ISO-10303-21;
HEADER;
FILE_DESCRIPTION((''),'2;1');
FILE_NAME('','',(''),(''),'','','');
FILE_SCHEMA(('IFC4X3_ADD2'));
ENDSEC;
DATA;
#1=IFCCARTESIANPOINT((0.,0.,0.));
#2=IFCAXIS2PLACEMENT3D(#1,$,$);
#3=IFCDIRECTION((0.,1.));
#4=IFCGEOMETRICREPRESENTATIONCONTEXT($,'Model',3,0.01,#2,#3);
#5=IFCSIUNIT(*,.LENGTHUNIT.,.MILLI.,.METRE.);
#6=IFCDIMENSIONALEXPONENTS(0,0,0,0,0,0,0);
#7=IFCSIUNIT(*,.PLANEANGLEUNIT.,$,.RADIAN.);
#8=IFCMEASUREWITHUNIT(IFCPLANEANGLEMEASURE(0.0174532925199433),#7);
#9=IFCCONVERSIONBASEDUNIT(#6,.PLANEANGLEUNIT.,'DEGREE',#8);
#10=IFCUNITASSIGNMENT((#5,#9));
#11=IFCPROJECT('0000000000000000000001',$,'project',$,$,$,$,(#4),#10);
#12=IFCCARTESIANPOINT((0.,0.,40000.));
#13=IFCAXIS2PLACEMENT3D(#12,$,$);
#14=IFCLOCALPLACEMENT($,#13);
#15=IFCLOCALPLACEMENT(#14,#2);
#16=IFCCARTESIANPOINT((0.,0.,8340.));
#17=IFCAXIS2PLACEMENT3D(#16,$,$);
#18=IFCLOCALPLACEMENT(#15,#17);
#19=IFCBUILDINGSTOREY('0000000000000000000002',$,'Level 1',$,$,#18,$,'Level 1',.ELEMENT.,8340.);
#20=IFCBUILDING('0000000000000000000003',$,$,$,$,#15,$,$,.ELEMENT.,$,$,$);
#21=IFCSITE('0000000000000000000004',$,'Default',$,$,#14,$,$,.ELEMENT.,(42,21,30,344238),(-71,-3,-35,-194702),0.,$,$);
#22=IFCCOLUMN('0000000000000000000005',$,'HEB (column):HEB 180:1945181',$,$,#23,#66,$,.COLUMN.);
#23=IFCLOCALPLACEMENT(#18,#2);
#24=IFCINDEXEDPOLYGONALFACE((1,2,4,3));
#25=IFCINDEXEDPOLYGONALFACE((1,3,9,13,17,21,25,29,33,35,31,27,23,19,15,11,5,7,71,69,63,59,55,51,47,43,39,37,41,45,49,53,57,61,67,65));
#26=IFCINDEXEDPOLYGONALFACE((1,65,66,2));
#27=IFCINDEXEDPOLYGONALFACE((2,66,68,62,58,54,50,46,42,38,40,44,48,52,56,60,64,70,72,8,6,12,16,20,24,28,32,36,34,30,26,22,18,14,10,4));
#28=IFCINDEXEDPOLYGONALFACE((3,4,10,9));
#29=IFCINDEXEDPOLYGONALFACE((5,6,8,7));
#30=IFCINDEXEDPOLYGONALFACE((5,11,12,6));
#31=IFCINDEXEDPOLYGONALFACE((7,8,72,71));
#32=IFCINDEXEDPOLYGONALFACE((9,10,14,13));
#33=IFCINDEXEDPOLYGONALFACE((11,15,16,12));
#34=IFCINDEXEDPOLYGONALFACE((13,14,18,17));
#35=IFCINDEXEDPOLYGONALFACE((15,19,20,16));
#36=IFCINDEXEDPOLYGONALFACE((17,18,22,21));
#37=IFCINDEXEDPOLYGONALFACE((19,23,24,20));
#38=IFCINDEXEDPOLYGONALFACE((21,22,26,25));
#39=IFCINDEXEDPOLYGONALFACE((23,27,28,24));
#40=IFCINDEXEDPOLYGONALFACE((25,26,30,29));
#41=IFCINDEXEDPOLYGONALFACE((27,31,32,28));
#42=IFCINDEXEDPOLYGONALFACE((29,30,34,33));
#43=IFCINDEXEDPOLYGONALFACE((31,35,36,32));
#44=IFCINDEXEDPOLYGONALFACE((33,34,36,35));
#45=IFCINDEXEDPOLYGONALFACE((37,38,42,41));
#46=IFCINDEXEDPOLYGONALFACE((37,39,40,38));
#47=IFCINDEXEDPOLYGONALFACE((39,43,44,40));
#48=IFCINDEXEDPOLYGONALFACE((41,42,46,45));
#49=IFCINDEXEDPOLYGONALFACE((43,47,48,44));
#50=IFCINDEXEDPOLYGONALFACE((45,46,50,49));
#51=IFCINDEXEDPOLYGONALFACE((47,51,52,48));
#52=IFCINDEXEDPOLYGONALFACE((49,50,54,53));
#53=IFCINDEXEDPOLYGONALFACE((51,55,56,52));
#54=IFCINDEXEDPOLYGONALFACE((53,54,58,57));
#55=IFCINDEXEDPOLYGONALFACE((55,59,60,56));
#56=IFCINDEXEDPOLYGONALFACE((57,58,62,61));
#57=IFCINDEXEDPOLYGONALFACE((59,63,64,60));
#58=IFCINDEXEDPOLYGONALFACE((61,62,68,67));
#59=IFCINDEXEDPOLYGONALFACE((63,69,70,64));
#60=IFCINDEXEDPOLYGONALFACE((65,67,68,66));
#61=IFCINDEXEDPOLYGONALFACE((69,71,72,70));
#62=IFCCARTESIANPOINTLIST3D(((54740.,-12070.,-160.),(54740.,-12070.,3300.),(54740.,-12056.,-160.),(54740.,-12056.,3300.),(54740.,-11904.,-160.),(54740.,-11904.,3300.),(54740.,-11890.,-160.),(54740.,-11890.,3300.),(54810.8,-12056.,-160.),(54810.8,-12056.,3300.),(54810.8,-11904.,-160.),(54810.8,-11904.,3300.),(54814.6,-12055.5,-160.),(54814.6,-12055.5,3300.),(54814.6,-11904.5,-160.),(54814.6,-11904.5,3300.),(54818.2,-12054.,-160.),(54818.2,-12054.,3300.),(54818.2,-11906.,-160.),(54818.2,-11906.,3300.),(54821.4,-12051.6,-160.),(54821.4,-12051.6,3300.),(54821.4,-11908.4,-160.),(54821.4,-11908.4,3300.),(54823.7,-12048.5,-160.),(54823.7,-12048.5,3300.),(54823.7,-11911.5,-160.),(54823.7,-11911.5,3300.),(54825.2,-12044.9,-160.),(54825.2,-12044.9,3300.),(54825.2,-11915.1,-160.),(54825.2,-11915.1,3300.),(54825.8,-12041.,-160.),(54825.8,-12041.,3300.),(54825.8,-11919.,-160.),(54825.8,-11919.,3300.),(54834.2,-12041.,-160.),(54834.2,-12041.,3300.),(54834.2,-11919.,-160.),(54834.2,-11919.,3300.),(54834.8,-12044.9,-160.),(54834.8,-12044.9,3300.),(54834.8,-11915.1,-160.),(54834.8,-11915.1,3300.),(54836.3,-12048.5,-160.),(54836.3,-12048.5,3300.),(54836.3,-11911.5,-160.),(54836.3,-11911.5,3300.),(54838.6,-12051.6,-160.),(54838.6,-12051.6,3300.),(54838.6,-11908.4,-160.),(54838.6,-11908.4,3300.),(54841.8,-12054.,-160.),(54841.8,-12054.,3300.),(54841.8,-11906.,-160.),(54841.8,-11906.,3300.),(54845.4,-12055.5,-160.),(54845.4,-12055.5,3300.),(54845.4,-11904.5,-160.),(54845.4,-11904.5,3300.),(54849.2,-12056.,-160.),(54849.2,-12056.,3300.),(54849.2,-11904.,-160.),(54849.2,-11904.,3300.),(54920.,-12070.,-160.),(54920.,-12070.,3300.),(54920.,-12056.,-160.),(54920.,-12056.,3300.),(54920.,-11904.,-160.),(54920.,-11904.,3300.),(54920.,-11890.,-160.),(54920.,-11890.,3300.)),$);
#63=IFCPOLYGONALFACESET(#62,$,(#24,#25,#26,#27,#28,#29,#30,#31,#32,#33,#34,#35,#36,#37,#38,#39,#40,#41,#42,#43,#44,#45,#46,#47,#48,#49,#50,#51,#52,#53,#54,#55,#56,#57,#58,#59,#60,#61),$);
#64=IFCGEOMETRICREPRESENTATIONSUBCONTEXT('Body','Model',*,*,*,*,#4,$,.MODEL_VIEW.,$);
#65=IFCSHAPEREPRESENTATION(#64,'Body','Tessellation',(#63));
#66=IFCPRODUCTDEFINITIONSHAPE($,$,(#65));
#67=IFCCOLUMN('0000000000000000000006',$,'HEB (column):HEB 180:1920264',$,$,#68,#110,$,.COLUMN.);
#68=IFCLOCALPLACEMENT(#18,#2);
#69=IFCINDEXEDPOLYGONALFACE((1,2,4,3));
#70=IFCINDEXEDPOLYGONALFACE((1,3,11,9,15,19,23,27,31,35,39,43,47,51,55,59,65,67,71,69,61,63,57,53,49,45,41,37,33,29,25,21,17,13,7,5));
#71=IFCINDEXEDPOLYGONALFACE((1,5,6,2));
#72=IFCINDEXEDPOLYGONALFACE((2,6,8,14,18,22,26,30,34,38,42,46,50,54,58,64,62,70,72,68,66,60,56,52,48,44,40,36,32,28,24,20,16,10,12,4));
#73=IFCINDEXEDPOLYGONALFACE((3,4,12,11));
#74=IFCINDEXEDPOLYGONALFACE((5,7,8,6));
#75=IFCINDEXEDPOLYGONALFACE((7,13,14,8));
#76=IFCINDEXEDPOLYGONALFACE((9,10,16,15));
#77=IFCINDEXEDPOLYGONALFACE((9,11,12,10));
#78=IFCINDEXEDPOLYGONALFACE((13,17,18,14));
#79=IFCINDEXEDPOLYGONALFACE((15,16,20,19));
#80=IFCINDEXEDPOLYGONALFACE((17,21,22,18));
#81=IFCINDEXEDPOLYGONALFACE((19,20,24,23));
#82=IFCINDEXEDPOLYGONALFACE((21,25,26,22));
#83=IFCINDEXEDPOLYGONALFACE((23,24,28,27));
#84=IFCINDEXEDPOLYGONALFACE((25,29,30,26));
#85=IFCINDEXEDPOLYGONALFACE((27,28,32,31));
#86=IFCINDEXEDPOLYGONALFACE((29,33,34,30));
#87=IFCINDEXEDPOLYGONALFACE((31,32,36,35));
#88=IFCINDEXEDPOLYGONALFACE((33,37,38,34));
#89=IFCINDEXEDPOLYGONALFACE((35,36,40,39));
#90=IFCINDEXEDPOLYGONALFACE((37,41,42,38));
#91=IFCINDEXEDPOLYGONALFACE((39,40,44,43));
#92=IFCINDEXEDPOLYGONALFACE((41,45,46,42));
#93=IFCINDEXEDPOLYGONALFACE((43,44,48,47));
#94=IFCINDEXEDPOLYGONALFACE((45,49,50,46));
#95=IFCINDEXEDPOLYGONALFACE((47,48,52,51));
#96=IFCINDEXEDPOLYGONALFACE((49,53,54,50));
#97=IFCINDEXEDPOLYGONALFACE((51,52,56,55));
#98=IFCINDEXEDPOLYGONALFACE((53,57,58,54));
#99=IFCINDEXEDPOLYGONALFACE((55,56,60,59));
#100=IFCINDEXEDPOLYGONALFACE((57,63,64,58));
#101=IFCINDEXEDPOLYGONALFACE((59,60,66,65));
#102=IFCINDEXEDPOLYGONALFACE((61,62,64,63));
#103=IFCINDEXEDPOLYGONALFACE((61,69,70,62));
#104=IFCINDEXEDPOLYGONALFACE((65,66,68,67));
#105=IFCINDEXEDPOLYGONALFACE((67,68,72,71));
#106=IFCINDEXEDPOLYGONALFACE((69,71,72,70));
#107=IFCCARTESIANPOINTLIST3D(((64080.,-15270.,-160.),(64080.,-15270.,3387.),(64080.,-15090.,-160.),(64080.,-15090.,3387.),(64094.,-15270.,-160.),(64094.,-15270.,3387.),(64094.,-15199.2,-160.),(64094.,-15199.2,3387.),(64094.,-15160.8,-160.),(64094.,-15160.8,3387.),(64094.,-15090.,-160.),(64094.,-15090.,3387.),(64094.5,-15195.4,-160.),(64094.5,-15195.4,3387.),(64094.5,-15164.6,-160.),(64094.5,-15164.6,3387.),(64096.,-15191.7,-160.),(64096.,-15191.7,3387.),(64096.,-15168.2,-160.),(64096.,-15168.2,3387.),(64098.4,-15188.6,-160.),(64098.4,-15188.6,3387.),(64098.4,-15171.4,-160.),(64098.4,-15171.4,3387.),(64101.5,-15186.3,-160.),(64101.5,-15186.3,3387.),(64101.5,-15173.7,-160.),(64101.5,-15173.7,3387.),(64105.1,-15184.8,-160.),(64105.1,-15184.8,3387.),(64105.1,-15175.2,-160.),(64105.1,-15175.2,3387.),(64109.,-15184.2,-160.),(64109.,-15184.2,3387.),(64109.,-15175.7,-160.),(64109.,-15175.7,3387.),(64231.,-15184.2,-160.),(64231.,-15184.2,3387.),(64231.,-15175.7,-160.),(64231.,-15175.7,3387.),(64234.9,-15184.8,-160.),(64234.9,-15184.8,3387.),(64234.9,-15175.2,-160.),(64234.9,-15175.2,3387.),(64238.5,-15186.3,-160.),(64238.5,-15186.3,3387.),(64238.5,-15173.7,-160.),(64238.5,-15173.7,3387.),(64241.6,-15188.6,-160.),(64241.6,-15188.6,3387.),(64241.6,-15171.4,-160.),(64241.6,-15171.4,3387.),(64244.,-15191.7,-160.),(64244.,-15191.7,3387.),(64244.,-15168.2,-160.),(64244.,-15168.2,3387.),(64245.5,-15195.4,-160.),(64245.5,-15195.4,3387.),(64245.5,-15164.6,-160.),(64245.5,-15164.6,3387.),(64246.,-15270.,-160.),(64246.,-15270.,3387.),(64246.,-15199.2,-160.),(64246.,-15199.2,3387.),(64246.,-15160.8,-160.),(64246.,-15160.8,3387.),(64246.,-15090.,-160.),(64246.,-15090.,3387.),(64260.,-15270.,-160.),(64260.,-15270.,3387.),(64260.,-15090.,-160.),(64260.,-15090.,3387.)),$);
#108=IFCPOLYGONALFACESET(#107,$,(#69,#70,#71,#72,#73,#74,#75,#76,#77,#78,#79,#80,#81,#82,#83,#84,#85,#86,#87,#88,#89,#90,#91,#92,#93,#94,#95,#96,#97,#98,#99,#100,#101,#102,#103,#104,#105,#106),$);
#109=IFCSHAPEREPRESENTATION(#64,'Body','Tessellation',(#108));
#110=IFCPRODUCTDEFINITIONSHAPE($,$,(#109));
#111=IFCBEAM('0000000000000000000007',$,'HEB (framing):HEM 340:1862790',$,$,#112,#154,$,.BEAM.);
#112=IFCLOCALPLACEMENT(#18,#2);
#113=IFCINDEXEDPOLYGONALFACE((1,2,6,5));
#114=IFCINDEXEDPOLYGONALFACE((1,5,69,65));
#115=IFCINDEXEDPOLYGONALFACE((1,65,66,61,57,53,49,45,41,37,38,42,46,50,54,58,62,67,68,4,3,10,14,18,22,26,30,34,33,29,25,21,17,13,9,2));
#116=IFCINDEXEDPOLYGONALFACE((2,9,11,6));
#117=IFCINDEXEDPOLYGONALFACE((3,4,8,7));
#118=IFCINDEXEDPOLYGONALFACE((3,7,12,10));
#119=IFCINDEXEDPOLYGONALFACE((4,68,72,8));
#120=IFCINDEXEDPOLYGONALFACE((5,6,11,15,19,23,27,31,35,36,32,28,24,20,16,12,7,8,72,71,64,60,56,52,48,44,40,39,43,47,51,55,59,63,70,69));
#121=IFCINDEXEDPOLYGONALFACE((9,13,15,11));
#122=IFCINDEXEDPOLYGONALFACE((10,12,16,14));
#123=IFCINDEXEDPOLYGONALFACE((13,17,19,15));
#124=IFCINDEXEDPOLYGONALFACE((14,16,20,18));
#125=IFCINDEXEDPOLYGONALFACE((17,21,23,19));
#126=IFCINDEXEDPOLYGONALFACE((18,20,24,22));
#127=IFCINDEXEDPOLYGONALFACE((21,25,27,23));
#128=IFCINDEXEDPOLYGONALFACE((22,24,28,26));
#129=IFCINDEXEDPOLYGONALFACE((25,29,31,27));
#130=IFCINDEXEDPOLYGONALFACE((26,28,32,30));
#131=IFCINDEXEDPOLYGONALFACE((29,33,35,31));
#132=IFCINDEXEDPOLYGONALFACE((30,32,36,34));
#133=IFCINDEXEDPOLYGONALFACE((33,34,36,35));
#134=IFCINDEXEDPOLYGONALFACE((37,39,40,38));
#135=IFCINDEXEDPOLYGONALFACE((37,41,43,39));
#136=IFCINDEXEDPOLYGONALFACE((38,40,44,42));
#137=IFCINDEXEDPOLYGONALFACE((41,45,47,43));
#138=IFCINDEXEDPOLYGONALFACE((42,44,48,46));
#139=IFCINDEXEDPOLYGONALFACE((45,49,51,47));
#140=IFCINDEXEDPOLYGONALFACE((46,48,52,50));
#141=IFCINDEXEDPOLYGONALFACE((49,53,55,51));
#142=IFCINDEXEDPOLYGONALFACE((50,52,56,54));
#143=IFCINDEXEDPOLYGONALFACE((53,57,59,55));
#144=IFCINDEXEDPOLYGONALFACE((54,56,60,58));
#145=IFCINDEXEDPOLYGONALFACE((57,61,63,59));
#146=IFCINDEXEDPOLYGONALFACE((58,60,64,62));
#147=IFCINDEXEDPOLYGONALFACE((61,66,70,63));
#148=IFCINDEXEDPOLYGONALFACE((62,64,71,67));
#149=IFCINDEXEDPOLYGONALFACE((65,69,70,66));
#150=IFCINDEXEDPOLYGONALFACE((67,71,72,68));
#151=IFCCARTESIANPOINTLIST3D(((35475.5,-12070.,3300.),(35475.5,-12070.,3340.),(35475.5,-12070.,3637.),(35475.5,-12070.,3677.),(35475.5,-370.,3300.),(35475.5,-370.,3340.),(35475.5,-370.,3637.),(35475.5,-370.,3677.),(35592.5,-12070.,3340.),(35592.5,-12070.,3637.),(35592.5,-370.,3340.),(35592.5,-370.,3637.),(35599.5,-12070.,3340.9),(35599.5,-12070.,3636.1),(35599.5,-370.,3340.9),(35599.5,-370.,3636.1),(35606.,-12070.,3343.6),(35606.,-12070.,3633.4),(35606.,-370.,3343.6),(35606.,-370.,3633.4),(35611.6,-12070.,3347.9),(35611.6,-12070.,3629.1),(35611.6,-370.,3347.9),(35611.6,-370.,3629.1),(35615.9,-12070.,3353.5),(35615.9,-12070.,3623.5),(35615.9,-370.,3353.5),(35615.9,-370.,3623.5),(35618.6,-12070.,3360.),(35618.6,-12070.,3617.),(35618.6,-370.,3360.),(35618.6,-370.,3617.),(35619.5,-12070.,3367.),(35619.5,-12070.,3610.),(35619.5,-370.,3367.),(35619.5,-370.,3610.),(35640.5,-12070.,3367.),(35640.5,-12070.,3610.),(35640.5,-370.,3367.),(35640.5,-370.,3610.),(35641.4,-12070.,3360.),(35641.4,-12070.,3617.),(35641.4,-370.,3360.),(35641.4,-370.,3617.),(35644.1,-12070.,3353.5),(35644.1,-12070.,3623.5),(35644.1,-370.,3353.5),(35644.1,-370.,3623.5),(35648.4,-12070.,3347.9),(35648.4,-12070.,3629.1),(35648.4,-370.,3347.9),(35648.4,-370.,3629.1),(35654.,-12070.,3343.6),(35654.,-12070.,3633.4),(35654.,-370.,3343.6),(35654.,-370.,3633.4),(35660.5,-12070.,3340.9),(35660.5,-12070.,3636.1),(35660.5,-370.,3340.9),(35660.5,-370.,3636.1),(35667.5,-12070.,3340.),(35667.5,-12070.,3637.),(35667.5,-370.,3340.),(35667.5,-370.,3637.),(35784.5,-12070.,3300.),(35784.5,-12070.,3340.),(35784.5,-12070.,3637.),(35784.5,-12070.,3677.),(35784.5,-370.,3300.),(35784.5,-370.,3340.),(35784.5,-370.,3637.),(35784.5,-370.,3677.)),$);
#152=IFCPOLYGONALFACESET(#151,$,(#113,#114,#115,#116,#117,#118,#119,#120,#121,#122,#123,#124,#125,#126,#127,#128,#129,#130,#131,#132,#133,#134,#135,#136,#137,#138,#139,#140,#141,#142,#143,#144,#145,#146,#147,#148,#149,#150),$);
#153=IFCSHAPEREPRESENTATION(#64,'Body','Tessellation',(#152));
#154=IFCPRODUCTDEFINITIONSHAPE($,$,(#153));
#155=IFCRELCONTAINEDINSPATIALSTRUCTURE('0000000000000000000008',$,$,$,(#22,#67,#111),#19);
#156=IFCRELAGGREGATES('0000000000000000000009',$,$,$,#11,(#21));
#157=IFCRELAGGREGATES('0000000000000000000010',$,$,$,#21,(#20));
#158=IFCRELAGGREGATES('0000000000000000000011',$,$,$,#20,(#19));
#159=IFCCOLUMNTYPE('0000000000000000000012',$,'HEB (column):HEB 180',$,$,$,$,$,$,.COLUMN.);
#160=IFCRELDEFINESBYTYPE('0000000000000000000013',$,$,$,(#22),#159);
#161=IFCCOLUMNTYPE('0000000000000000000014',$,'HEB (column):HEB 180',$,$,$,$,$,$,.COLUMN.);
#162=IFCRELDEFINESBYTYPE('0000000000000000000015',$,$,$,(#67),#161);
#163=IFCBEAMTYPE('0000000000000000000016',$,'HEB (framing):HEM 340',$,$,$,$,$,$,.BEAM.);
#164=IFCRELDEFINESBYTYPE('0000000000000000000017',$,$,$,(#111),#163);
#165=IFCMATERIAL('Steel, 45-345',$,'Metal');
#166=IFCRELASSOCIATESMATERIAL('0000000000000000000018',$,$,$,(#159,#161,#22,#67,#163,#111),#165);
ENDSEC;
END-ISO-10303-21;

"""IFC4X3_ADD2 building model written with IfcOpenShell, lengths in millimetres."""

from ifc_helpers import new_model, entity, si_unit, converted_unit, direction, frame, frame_2d, origin, origin_2d_with_axis, place, context, subcontext, project, spatial, polyline, circle_curve, parameter, trimmed, segment, composite_curve, i_section, outline, extrude, source, transform, mapped, material, material_profile, profile_set, profile_usage, type_object, type_shapes, element, save


model = new_model("IFC4X3_ADD2")

# Units and contexts
model_context = context("Model", 3, precision=0.01, world=origin(), true_north=direction((0.0, 1.0)))
body_context = subcontext(model_context, "Body", "Model", "MODEL_VIEW")
ifc_project = project(units=[si_unit("LENGTHUNIT", "METRE", prefix="MILLI"), converted_unit("PLANEANGLEUNIT", "DEGREE", entity("IfcPlaneAngleMeasure", 0.0174532925199433), si_unit("PLANEANGLEUNIT", "RADIAN"), dimensions=[0, 0, 0, 0, 0, 0, 0])], contexts=[model_context])

# Site, building, storey
site_placement = place(None, frame((0.0, 0.0, 40000.0)))
site = spatial("IfcSite", under=ifc_project, at=site_placement, Name="Default", CompositionType="ELEMENT", RefLatitude=(42, 21, 30, 344238), RefLongitude=(-71, -3, -35, -194702), RefElevation=0.0)
building_placement = place(site_placement, origin())
building = spatial("IfcBuilding", under=site, at=building_placement, CompositionType="ELEMENT")
storey_placement = place(building_placement, frame((0.0, 0.0, 8340.0)))
storey = spatial("IfcBuildingStorey", under=building, at=storey_placement, Name="Level 1", LongName="Level 1", CompositionType="ELEMENT", Elevation=8340.0)

# Columns
ifc_material = material(Name="Steel, 45-345", Category="Metal")
ifc_material_profile_1 = material_profile(ifc_material, i_section(OverallWidth=180.0, OverallDepth=180.0, WebThickness=8.5, FlangeThickness=14.0, FilletRadius=15.0, at=origin_2d_with_axis()), Name="HEB 180")
ifc_profile_set_1 = profile_set([ifc_material_profile_1], Name="HEB 180")
ifc_profile_usage_1 = profile_usage(ifc_profile_set_1)
column_type_1 = type_object("IfcColumnType", Name="HEB (column):HEB 180", PredefinedType="COLUMN", material=ifc_profile_set_1)
shared_shape_1 = source(origin(), body_context, "Body", "SweptSolid", [
    extrude(i_section(OverallWidth=180.0, OverallDepth=180.0, WebThickness=8.5, FlangeThickness=14.0, FilletRadius=15.0, at=origin_2d_with_axis()), frame((0.0, 0.0, 8180.0), z_axis=(0.0, 0.0, 1.0), x_axis=(-1.0, 0.0, 0.0)), (0.0, 0.0, 1.0), 3460.0),
])
type_shapes(column_type_1, [shared_shape_1])
column_1_placement = place(storey_placement, frame((54830.0, -11980.0, -8340.0)))
element("IfcColumn", 1, at=column_1_placement, inside=storey, type_object=column_type_1, material=ifc_profile_usage_1, Name="HEB (column):HEB 180:1945181", PredefinedType="COLUMN", context=body_context, shape_type="MappedRepresentation", body=[
    mapped(shared_shape_1, transform((0.0, 0.0, 0.0), scale=1.0)),
])
column_type_2 = type_object("IfcColumnType", Name="HEB (column):HEB 180", PredefinedType="COLUMN", material=ifc_profile_set_1)
shared_shape_2 = source(origin(), body_context, "Body", "SweptSolid", [
    extrude(i_section(OverallWidth=180.0, OverallDepth=180.0, WebThickness=8.5, FlangeThickness=14.0, FilletRadius=15.0, at=origin_2d_with_axis()), frame((0.0, 0.0, 8180.0), z_axis=(0.0, 0.0, 1.0), x_axis=(-1.0, 0.0, 0.0)), (0.0, 0.0, 1.0), 3547.0),
])
type_shapes(column_type_2, [shared_shape_2])
column_2_placement = place(storey_placement, frame((64170.0, -15180.0, -8340.0), z_axis=(0.0, 0.0, 1.0), x_axis=(0.0, -1.0, 0.0)))
element("IfcColumn", 2, at=column_2_placement, inside=storey, type_object=column_type_2, material=ifc_profile_usage_1, Name="HEB (column):HEB 180:1920264", PredefinedType="COLUMN", context=body_context, shape_type="MappedRepresentation", body=[
    mapped(shared_shape_2, transform((0.0, 0.0, 0.0), scale=1.0)),
])

# Beam
ifc_material_profile_2 = material_profile(ifc_material, outline(composite_curve([segment(polyline([(-154.5, -148.5), (-154.5, -188.5)]), True, "CONTINUOUS"), segment(polyline([(-154.5, -188.5), (154.5, -188.5)]), True, "CONTINUOUS"), segment(polyline([(154.5, -188.5), (154.5, -148.5)]), True, "CONTINUOUS"), segment(polyline([(154.5, -148.5), (37.5, -148.5)]), True, "CONTINUOUS"), segment(trimmed(circle_curve(frame_2d((37.5, -121.5), x_axis=(1.0, 0.0)), 27.0), [parameter(180.0)], [parameter(270.0)], True, "PARAMETER"), False, "CONTINUOUS"), segment(polyline([(10.5, -121.5), (10.5, 121.5)]), True, "CONTINUOUS"), segment(trimmed(circle_curve(frame_2d((37.5, 121.5), x_axis=(1.0, 0.0)), 27.0), [parameter(90.0)], [parameter(180.0)], True, "PARAMETER"), False, "CONTINUOUS"), segment(polyline([(37.5, 148.5), (154.5, 148.5)]), True, "CONTINUOUS"), segment(polyline([(154.5, 148.5), (154.5, 188.5)]), True, "CONTINUOUS"), segment(polyline([(154.5, 188.5), (-154.5, 188.5)]), True, "CONTINUOUS"), segment(polyline([(-154.5, 188.5), (-154.5, 148.5)]), True, "CONTINUOUS"), segment(polyline([(-154.5, 148.5), (-37.5, 148.5)]), True, "CONTINUOUS"), segment(trimmed(circle_curve(frame_2d((-37.5, 121.5), x_axis=(1.0, 0.0)), 27.0), [parameter(360.0)], [parameter(90.0)], True, "PARAMETER"), False, "CONTINUOUS"), segment(polyline([(-10.5, 121.5), (-10.5, -121.5)]), True, "CONTINUOUS"), segment(trimmed(circle_curve(frame_2d((-37.5, -121.5), x_axis=(1.0, 0.0)), 27.0), [parameter(270.0)], [parameter(0.0)], True, "PARAMETER"), False, "CONTINUOUS"), segment(polyline([(-37.5, -148.5), (-154.5, -148.5)]), True, "CONTINUOUS")], self_intersect=False)), Name="HEM 340")
ifc_profile_set_2 = profile_set([ifc_material_profile_2], Name="HEM 340")
ifc_profile_usage_2 = profile_usage(ifc_profile_set_2, cardinal=8)
beam_type_1 = type_object("IfcBeamType", Name="HEB (framing):HEM 340", PredefinedType="BEAM", material=ifc_profile_set_2)
shared_shape_3 = source(origin(), body_context, "Body", "SweptSolid", [
    extrude(outline(composite_curve([segment(polyline([(-154.5, -148.5), (-154.5, -188.5)]), True, "CONTINUOUS"), segment(polyline([(-154.5, -188.5), (154.5, -188.5)]), True, "CONTINUOUS"), segment(polyline([(154.5, -188.5), (154.5, -148.5)]), True, "CONTINUOUS"), segment(polyline([(154.5, -148.5), (37.5, -148.5)]), True, "CONTINUOUS"), segment(trimmed(circle_curve(frame_2d((37.5, -121.5), x_axis=(1.0, 0.0)), 27.0), [parameter(180.0)], [parameter(270.0)], True, "PARAMETER"), False, "CONTINUOUS"), segment(polyline([(10.5, -121.5), (10.5, 121.5)]), True, "CONTINUOUS"), segment(trimmed(circle_curve(frame_2d((37.5, 121.5), x_axis=(1.0, 0.0)), 27.0), [parameter(90.0)], [parameter(180.0)], True, "PARAMETER"), False, "CONTINUOUS"), segment(polyline([(37.5, 148.5), (154.5, 148.5)]), True, "CONTINUOUS"), segment(polyline([(154.5, 148.5), (154.5, 188.5)]), True, "CONTINUOUS"), segment(polyline([(154.5, 188.5), (-154.5, 188.5)]), True, "CONTINUOUS"), segment(polyline([(-154.5, 188.5), (-154.5, 148.5)]), True, "CONTINUOUS"), segment(polyline([(-154.5, 148.5), (-37.5, 148.5)]), True, "CONTINUOUS"), segment(trimmed(circle_curve(frame_2d((-37.5, 121.5), x_axis=(1.0, 0.0)), 27.0), [parameter(360.0)], [parameter(90.0)], True, "PARAMETER"), False, "CONTINUOUS"), segment(polyline([(-10.5, 121.5), (-10.5, -121.5)]), True, "CONTINUOUS"), segment(trimmed(circle_curve(frame_2d((-37.5, -121.5), x_axis=(1.0, 0.0)), 27.0), [parameter(270.0)], [parameter(0.0)], True, "PARAMETER"), False, "CONTINUOUS"), segment(polyline([(-37.5, -148.5), (-154.5, -148.5)]), True, "CONTINUOUS")], self_intersect=False)), frame((-5850.0, 0.0, 0.0), z_axis=(-1.0, 0.0, 0.0), x_axis=(0.0, -1.0, 0.0)), (0.0, 0.0, -1.0), 11700.0),
])
type_shapes(beam_type_1, [shared_shape_3])
for number, where, z_axis, x_axis, name in (
    (3, (35630.0, -6220.0, 3488.5), (0.0, 0.0, 1.0), (0.0, -1.0, 0.0), "HEB (framing):HEM 340:1862790"),
):
    element("IfcBeam", number, at=place(storey_placement, frame(where, z_axis=z_axis, x_axis=x_axis)), inside=storey, type_object=beam_type_1, material=ifc_profile_usage_2, Name=name, PredefinedType="BEAM", context=body_context, shape_type="MappedRepresentation", body=[
        mapped(shared_shape_3, transform((0.0, 0.0, 0.0), scale=1.0)),
    ])

save(model, "model.ifc")
